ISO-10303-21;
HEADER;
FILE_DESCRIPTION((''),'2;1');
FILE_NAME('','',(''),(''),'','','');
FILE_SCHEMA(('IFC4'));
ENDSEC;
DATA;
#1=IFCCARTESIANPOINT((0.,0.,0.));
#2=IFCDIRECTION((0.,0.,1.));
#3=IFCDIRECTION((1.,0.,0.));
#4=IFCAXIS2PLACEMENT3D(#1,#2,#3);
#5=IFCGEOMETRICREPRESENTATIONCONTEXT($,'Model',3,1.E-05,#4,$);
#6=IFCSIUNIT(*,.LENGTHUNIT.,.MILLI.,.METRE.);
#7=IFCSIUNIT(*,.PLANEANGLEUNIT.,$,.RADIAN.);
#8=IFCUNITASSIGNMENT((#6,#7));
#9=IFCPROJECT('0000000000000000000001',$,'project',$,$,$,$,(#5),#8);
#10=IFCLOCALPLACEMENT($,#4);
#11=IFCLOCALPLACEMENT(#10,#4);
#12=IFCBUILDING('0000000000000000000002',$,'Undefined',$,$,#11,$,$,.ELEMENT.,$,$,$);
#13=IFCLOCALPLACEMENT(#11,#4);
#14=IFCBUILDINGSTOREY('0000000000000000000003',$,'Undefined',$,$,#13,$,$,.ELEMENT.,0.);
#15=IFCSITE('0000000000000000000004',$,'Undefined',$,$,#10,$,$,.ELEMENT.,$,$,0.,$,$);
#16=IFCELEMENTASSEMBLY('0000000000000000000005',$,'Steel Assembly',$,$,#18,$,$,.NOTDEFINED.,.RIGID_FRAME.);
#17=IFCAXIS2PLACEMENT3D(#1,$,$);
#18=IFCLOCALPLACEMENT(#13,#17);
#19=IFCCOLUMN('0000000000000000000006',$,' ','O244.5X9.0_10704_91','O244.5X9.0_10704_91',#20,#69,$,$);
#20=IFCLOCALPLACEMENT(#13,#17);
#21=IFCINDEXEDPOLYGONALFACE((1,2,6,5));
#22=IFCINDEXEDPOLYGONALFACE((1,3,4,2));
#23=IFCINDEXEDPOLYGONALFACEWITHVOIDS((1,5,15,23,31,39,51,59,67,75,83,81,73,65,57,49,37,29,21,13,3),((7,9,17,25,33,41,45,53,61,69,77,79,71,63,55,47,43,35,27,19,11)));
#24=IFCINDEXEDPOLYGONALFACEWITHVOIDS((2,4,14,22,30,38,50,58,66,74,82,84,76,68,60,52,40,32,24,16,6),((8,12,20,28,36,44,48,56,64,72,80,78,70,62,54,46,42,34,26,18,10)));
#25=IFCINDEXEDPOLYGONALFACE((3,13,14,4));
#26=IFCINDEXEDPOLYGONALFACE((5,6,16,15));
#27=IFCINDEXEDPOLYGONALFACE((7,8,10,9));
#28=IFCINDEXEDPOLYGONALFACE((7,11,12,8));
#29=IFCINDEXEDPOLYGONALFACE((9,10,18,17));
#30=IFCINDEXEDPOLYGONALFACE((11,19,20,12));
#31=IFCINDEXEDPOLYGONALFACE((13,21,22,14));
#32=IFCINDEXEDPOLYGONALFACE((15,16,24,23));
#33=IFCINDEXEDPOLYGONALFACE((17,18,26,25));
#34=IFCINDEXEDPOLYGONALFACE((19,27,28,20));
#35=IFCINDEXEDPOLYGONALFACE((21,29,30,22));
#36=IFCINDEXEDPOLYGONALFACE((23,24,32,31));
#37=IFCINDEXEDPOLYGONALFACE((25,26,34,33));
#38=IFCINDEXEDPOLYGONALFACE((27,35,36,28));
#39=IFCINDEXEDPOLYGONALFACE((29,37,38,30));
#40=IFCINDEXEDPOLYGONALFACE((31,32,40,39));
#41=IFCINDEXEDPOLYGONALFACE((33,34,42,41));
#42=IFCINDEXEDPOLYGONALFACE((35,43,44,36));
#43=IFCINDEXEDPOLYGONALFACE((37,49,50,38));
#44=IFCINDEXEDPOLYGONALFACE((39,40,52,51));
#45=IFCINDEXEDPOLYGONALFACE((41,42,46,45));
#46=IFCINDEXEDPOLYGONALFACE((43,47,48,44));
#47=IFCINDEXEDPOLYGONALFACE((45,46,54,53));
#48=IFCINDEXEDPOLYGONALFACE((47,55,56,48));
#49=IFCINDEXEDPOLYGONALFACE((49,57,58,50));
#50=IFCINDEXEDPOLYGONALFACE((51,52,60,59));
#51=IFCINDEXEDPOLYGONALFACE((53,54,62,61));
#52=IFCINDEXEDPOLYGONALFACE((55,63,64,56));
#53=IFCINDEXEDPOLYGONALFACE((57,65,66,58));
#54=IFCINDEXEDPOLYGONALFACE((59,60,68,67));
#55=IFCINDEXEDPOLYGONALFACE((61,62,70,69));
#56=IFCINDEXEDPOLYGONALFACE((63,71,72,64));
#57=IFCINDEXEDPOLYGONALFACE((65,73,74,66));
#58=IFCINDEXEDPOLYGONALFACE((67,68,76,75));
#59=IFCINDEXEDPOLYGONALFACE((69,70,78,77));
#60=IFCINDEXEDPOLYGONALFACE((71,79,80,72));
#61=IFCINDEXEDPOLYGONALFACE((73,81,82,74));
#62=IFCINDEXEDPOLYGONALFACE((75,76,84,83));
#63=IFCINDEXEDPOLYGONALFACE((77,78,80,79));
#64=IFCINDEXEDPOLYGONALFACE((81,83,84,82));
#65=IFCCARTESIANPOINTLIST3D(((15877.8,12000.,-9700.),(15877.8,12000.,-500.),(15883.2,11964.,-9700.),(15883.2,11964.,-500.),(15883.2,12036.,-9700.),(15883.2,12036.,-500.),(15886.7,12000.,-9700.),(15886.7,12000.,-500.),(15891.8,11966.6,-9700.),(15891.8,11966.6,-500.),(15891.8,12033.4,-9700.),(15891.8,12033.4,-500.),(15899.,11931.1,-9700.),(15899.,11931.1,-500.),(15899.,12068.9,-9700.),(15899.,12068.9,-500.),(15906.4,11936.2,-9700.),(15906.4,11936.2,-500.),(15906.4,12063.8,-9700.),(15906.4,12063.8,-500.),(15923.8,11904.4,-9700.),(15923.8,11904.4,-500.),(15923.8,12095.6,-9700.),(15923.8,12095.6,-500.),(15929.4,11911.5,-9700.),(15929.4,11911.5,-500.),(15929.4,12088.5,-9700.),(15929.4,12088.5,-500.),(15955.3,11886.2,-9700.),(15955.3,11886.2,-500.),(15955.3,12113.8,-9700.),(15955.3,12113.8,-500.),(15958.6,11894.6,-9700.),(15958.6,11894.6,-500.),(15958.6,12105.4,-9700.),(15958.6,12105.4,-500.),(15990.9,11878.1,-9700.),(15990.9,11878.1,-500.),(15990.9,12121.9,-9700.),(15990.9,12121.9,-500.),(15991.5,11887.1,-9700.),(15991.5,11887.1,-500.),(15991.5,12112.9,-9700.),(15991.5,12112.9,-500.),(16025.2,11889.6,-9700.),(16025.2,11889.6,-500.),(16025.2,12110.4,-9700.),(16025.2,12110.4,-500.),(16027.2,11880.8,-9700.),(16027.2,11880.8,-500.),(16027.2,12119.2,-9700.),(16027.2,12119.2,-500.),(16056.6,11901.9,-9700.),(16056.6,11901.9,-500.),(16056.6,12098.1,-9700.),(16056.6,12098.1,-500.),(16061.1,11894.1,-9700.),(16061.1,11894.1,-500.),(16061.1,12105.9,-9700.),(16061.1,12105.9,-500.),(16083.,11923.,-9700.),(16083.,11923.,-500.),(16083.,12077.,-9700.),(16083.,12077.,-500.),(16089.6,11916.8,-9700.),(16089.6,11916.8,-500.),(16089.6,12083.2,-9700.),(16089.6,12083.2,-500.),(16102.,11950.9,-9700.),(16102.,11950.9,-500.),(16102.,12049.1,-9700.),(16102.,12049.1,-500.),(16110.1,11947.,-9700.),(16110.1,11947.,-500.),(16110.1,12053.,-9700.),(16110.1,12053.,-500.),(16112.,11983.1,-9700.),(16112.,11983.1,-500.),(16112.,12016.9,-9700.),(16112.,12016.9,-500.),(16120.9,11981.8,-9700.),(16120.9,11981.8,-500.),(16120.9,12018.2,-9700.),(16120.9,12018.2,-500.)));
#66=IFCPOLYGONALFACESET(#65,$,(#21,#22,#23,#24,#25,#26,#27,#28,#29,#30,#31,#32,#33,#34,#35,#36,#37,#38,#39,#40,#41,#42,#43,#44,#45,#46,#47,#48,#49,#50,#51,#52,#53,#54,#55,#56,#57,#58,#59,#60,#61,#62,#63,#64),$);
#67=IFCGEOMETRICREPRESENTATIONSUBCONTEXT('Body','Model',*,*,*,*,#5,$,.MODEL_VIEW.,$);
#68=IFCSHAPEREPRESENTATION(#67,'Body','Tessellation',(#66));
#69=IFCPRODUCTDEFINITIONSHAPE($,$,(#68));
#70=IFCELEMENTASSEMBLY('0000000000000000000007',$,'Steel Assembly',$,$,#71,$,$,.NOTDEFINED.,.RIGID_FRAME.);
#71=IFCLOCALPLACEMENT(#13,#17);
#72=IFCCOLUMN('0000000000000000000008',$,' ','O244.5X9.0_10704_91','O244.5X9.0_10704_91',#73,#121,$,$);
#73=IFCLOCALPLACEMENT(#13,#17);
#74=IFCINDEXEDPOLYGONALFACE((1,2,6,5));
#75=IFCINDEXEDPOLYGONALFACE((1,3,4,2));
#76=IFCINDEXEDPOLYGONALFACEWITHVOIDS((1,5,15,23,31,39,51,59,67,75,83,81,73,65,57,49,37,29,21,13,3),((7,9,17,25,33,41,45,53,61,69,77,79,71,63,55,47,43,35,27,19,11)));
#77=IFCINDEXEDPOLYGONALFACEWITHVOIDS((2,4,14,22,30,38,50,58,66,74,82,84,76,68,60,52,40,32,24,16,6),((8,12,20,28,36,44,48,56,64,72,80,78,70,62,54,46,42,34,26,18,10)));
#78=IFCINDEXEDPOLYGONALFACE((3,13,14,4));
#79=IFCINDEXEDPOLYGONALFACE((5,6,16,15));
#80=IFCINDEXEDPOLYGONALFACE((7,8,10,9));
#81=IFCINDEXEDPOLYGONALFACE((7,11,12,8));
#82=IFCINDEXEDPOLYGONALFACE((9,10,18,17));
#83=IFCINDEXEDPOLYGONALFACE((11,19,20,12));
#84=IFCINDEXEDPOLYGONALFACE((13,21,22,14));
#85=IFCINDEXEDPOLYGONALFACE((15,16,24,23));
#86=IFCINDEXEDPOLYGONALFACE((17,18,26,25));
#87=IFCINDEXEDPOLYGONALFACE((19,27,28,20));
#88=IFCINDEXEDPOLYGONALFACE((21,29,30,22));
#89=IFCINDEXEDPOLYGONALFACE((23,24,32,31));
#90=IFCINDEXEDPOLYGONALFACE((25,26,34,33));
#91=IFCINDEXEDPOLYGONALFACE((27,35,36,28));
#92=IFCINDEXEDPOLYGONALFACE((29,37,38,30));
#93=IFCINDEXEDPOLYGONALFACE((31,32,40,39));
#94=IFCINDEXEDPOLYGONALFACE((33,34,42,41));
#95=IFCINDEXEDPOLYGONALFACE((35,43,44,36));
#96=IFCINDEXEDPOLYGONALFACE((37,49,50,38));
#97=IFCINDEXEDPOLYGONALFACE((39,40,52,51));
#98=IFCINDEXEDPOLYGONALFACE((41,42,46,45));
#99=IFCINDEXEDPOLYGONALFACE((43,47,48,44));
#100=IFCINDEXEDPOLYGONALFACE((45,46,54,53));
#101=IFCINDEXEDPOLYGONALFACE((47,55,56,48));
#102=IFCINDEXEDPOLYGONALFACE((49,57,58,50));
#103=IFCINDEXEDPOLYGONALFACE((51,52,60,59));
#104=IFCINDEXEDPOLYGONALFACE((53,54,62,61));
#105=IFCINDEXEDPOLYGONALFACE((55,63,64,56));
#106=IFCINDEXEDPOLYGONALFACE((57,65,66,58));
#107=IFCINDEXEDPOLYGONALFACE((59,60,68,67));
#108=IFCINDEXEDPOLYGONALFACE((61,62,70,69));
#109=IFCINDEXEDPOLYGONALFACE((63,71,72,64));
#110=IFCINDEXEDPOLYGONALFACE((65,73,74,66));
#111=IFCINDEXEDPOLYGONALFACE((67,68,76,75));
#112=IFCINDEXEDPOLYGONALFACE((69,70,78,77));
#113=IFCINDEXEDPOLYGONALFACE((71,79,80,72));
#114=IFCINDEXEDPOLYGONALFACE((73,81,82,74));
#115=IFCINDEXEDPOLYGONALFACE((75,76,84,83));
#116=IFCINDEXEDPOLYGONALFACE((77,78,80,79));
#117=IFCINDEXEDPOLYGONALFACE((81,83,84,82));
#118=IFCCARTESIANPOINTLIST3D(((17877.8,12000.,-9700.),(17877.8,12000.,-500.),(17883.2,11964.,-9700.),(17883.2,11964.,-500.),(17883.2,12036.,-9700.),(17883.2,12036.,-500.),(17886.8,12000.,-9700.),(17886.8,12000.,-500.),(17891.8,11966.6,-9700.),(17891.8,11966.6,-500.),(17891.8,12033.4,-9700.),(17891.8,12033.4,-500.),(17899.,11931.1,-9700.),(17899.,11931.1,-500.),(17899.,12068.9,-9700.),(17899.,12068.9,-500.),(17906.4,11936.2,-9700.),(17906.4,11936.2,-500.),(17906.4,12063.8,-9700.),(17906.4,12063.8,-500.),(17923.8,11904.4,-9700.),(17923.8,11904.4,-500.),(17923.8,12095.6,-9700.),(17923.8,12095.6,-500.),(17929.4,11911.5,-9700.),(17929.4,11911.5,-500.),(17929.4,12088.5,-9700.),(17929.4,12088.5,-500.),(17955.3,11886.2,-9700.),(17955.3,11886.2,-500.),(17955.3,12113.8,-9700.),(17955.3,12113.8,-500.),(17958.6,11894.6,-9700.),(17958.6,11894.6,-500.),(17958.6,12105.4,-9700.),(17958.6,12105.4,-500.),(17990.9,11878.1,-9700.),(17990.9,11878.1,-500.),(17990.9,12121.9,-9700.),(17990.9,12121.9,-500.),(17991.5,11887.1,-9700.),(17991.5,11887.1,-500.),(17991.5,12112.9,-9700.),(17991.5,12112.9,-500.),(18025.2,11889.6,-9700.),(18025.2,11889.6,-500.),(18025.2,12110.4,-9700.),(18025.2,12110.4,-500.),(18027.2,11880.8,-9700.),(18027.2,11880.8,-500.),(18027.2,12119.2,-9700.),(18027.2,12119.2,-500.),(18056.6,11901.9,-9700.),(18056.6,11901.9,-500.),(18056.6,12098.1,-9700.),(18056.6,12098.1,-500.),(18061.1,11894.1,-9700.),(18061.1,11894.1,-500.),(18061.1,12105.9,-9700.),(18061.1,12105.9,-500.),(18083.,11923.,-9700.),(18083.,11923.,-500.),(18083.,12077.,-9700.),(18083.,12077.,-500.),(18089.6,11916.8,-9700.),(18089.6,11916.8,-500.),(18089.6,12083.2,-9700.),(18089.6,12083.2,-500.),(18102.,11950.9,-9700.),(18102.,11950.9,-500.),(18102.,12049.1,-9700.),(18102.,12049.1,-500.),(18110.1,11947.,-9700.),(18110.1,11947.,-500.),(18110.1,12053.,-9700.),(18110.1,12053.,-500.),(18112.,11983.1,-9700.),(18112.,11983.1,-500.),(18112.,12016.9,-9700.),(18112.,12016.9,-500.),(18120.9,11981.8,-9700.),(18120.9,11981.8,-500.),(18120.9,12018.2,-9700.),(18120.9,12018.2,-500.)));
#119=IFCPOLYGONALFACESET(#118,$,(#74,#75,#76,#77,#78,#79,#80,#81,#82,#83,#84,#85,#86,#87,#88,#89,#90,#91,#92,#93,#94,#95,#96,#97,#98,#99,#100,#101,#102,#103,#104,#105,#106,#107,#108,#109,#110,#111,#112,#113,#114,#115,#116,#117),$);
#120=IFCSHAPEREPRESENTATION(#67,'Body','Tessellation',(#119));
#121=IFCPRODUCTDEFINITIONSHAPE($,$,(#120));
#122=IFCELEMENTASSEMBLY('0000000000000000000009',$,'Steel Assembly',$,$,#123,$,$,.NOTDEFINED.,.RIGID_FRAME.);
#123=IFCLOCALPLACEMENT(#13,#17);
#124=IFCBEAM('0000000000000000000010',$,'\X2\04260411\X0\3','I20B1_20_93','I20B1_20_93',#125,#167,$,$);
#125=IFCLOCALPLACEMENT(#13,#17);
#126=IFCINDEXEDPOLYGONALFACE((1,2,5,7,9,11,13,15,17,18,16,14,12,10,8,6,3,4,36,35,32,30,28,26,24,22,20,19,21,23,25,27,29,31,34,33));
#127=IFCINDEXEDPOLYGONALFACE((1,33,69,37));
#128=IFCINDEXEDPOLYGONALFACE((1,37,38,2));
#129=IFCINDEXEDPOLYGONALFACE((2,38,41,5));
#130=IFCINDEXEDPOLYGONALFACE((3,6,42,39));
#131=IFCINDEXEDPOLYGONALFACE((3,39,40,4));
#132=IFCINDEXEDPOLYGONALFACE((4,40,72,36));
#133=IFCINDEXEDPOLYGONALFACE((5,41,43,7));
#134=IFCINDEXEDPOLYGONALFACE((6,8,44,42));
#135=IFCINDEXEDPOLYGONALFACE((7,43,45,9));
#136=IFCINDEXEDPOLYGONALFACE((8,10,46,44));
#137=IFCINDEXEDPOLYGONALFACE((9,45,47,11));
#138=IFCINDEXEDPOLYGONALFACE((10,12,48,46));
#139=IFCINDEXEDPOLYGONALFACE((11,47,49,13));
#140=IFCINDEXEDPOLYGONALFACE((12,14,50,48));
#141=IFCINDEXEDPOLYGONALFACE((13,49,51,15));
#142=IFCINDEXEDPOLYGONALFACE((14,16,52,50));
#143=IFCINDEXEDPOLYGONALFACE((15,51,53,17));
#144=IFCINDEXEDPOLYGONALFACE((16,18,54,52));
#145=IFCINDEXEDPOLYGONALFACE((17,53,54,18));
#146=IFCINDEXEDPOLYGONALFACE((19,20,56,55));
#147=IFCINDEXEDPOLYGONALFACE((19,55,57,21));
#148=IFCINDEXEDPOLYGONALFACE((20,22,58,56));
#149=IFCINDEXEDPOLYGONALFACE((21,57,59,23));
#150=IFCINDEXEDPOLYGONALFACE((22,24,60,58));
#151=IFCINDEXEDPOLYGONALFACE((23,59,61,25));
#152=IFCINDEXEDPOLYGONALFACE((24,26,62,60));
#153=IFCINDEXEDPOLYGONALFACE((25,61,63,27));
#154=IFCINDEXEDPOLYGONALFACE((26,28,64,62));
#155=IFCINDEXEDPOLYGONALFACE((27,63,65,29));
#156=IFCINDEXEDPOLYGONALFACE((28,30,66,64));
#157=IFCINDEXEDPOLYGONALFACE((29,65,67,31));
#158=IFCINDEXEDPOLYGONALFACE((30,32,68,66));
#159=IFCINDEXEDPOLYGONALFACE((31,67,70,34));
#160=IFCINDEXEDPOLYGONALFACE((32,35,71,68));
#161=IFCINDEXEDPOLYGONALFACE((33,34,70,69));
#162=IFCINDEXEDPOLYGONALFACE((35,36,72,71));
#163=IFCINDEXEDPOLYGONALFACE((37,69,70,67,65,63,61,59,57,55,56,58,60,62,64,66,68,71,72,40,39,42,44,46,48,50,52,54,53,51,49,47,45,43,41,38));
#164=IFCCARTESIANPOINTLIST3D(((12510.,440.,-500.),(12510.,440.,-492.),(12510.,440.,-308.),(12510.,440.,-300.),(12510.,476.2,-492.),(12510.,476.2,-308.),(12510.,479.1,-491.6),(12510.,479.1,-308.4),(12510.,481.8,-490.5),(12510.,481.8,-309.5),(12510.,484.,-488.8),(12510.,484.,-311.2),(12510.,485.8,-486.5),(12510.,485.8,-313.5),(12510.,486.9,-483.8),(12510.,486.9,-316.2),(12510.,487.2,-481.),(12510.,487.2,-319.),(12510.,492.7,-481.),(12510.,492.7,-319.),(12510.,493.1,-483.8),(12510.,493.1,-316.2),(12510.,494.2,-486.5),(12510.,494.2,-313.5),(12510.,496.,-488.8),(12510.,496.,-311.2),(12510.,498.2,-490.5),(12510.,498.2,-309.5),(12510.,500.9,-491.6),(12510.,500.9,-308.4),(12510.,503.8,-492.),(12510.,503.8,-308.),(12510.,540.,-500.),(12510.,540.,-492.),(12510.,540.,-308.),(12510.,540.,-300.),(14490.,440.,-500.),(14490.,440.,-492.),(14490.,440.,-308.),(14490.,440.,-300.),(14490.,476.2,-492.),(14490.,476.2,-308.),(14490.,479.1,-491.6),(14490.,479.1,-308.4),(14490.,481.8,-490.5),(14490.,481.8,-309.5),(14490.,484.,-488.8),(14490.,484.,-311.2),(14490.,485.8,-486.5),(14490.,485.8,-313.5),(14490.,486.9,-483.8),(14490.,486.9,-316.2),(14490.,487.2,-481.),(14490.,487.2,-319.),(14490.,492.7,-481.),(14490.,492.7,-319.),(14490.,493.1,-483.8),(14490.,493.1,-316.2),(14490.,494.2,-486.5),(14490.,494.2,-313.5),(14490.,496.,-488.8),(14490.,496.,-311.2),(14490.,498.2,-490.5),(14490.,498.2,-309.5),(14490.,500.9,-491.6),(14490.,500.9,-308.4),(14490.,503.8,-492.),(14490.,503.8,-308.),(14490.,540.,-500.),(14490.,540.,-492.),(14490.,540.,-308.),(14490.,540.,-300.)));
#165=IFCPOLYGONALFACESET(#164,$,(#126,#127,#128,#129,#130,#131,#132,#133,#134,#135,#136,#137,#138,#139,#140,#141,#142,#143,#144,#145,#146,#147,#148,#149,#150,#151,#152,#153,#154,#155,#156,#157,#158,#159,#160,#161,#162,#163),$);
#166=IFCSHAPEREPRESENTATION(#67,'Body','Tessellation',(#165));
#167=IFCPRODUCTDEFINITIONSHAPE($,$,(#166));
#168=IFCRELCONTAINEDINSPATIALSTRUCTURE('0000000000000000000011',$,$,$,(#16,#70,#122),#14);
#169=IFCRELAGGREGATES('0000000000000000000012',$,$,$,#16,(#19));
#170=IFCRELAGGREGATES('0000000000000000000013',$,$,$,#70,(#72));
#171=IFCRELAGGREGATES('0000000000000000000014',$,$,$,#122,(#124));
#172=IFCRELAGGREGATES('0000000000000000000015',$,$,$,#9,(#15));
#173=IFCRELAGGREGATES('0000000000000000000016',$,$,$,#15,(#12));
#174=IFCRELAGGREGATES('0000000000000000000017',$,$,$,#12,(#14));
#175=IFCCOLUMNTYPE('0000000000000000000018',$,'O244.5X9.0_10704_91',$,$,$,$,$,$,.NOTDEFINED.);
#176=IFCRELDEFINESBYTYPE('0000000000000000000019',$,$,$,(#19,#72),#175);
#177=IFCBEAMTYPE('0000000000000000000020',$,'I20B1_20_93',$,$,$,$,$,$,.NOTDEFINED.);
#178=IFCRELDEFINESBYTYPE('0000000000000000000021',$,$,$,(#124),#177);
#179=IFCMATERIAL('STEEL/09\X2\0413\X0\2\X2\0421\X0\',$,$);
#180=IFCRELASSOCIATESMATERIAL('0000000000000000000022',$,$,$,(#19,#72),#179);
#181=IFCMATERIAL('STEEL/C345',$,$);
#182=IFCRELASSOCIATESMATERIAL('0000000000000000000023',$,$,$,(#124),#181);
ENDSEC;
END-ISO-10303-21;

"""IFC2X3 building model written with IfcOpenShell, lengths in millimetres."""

from ifc_helpers import new_model, si_unit, frame, origin_with_axes, origin_2d_with_axis, place, context, subcontext, project, spatial, hollow_circle, i_section, extrude, material, type_object, element, aggregate, save


model = new_model("IFC2X3")

# Units and contexts
model_context = context("Model", 3, precision=1e-05, world=origin_with_axes())
body_context = subcontext(model_context, "Body", "Model", "MODEL_VIEW")
ifc_project = project(units=[si_unit("LENGTHUNIT", "METRE", prefix="MILLI"), si_unit("PLANEANGLEUNIT", "RADIAN")], contexts=[model_context])

# Site, building, storey
site_placement = place(None, origin_with_axes())
site = spatial("IfcSite", under=ifc_project, at=site_placement, Name="Undefined", CompositionType="ELEMENT", RefElevation=0.0)
building_placement = place(site_placement, origin_with_axes())
building = spatial("IfcBuilding", under=site, at=building_placement, Name="Undefined", CompositionType="ELEMENT")
storey_placement = place(building_placement, origin_with_axes())
storey = spatial("IfcBuildingStorey", under=building, at=storey_placement, Name="Undefined", CompositionType="ELEMENT", Elevation=0.0)

# Element assemblies, columns
ifc_material_1 = material(Name="STEEL/C345")
ifc_material_2 = material(Name="STEEL/09Г2С")
column_type_1 = type_object("IfcColumnType", Name="O244.5X9.0_10704_91", PredefinedType="NOTDEFINED")
assembly_1_placement = place(storey_placement, origin_with_axes())
assembly_1 = element("IfcElementAssembly", 1, at=assembly_1_placement, inside=storey, Name="Steel Assembly", AssemblyPlace="NOTDEFINED", PredefinedType="RIGID_FRAME")
column_1_placement = place(assembly_1_placement, frame((16000.0, 12000.0, -9700.0), z_axis=(0.0, 0.0, 1.0), x_axis=(0.0, 1.0, 0.0)))
column_1 = element("IfcColumn", 2, at=column_1_placement, type_object=column_type_1, material=ifc_material_2, Name=" ", Description="O244.5X9.0_10704_91", ObjectType="O244.5X9.0_10704_91", context=body_context, shape_type="SweptSolid", body=[
    extrude(hollow_circle(Radius=122.2, WallThickness=9.0, at=origin_2d_with_axis()), frame((0.0, 0.0, 9200.0), z_axis=(0.0, 0.0, -1.0), x_axis=(0.0, 1.0, 0.0)), (0.0, 0.0, 1.0), 9200.0),
])
aggregate(assembly_1, [column_1])
assembly_2_placement = place(storey_placement, origin_with_axes())
assembly_2 = element("IfcElementAssembly", 3, at=assembly_2_placement, inside=storey, Name="Steel Assembly", AssemblyPlace="NOTDEFINED", PredefinedType="RIGID_FRAME")
column_2_placement = place(assembly_2_placement, frame((18000.0, 12000.0, -9700.0), z_axis=(0.0, 0.0, 1.0), x_axis=(0.0, 1.0, 0.0)))
column_2 = element("IfcColumn", 4, at=column_2_placement, type_object=column_type_1, material=ifc_material_2, Name=" ", Description="O244.5X9.0_10704_91", ObjectType="O244.5X9.0_10704_91", context=body_context, shape_type="SweptSolid", body=[
    extrude(hollow_circle(Radius=122.2, WallThickness=9.0, at=origin_2d_with_axis()), frame((0.0, 0.0, 9200.0), z_axis=(0.0, 0.0, -1.0), x_axis=(0.0, 1.0, 0.0)), (0.0, 0.0, 1.0), 9200.0),
])
aggregate(assembly_2, [column_2])

# Element assembly, beam
assembly_3_placement = place(storey_placement, origin_with_axes())
assembly_3 = element("IfcElementAssembly", 5, at=assembly_3_placement, inside=storey, Name="Steel Assembly", AssemblyPlace="NOTDEFINED", PredefinedType="RIGID_FRAME")
beam_type_1 = type_object("IfcBeamType", Name="I20B1_20_93", PredefinedType="NOTDEFINED")
beam_1_placement = place(assembly_3_placement, frame((12510.0, 490.0, -400.0), z_axis=(0.0, 0.0, 1.0), x_axis=(1.0, 0.0, 0.0)))
beam_1 = element("IfcBeam", 6, at=beam_1_placement, type_object=beam_type_1, material=ifc_material_1, Name="ЦБ3", Description="I20B1_20_93", ObjectType="I20B1_20_93", context=body_context, shape_type="SweptSolid", body=[
    extrude(i_section(OverallWidth=100.0, OverallDepth=200.0, WebThickness=5.5, FlangeThickness=8.0, FilletRadius=11.0, at=origin_2d_with_axis()), frame((1980.0, 0.0, 0.0), z_axis=(-1.0, 0.0, 0.0), x_axis=(0.0, -1.0, 0.0)), (0.0, 0.0, 1.0), 1980.0),
])
aggregate(assembly_3, [beam_1])

save(model, "model.ifc")
